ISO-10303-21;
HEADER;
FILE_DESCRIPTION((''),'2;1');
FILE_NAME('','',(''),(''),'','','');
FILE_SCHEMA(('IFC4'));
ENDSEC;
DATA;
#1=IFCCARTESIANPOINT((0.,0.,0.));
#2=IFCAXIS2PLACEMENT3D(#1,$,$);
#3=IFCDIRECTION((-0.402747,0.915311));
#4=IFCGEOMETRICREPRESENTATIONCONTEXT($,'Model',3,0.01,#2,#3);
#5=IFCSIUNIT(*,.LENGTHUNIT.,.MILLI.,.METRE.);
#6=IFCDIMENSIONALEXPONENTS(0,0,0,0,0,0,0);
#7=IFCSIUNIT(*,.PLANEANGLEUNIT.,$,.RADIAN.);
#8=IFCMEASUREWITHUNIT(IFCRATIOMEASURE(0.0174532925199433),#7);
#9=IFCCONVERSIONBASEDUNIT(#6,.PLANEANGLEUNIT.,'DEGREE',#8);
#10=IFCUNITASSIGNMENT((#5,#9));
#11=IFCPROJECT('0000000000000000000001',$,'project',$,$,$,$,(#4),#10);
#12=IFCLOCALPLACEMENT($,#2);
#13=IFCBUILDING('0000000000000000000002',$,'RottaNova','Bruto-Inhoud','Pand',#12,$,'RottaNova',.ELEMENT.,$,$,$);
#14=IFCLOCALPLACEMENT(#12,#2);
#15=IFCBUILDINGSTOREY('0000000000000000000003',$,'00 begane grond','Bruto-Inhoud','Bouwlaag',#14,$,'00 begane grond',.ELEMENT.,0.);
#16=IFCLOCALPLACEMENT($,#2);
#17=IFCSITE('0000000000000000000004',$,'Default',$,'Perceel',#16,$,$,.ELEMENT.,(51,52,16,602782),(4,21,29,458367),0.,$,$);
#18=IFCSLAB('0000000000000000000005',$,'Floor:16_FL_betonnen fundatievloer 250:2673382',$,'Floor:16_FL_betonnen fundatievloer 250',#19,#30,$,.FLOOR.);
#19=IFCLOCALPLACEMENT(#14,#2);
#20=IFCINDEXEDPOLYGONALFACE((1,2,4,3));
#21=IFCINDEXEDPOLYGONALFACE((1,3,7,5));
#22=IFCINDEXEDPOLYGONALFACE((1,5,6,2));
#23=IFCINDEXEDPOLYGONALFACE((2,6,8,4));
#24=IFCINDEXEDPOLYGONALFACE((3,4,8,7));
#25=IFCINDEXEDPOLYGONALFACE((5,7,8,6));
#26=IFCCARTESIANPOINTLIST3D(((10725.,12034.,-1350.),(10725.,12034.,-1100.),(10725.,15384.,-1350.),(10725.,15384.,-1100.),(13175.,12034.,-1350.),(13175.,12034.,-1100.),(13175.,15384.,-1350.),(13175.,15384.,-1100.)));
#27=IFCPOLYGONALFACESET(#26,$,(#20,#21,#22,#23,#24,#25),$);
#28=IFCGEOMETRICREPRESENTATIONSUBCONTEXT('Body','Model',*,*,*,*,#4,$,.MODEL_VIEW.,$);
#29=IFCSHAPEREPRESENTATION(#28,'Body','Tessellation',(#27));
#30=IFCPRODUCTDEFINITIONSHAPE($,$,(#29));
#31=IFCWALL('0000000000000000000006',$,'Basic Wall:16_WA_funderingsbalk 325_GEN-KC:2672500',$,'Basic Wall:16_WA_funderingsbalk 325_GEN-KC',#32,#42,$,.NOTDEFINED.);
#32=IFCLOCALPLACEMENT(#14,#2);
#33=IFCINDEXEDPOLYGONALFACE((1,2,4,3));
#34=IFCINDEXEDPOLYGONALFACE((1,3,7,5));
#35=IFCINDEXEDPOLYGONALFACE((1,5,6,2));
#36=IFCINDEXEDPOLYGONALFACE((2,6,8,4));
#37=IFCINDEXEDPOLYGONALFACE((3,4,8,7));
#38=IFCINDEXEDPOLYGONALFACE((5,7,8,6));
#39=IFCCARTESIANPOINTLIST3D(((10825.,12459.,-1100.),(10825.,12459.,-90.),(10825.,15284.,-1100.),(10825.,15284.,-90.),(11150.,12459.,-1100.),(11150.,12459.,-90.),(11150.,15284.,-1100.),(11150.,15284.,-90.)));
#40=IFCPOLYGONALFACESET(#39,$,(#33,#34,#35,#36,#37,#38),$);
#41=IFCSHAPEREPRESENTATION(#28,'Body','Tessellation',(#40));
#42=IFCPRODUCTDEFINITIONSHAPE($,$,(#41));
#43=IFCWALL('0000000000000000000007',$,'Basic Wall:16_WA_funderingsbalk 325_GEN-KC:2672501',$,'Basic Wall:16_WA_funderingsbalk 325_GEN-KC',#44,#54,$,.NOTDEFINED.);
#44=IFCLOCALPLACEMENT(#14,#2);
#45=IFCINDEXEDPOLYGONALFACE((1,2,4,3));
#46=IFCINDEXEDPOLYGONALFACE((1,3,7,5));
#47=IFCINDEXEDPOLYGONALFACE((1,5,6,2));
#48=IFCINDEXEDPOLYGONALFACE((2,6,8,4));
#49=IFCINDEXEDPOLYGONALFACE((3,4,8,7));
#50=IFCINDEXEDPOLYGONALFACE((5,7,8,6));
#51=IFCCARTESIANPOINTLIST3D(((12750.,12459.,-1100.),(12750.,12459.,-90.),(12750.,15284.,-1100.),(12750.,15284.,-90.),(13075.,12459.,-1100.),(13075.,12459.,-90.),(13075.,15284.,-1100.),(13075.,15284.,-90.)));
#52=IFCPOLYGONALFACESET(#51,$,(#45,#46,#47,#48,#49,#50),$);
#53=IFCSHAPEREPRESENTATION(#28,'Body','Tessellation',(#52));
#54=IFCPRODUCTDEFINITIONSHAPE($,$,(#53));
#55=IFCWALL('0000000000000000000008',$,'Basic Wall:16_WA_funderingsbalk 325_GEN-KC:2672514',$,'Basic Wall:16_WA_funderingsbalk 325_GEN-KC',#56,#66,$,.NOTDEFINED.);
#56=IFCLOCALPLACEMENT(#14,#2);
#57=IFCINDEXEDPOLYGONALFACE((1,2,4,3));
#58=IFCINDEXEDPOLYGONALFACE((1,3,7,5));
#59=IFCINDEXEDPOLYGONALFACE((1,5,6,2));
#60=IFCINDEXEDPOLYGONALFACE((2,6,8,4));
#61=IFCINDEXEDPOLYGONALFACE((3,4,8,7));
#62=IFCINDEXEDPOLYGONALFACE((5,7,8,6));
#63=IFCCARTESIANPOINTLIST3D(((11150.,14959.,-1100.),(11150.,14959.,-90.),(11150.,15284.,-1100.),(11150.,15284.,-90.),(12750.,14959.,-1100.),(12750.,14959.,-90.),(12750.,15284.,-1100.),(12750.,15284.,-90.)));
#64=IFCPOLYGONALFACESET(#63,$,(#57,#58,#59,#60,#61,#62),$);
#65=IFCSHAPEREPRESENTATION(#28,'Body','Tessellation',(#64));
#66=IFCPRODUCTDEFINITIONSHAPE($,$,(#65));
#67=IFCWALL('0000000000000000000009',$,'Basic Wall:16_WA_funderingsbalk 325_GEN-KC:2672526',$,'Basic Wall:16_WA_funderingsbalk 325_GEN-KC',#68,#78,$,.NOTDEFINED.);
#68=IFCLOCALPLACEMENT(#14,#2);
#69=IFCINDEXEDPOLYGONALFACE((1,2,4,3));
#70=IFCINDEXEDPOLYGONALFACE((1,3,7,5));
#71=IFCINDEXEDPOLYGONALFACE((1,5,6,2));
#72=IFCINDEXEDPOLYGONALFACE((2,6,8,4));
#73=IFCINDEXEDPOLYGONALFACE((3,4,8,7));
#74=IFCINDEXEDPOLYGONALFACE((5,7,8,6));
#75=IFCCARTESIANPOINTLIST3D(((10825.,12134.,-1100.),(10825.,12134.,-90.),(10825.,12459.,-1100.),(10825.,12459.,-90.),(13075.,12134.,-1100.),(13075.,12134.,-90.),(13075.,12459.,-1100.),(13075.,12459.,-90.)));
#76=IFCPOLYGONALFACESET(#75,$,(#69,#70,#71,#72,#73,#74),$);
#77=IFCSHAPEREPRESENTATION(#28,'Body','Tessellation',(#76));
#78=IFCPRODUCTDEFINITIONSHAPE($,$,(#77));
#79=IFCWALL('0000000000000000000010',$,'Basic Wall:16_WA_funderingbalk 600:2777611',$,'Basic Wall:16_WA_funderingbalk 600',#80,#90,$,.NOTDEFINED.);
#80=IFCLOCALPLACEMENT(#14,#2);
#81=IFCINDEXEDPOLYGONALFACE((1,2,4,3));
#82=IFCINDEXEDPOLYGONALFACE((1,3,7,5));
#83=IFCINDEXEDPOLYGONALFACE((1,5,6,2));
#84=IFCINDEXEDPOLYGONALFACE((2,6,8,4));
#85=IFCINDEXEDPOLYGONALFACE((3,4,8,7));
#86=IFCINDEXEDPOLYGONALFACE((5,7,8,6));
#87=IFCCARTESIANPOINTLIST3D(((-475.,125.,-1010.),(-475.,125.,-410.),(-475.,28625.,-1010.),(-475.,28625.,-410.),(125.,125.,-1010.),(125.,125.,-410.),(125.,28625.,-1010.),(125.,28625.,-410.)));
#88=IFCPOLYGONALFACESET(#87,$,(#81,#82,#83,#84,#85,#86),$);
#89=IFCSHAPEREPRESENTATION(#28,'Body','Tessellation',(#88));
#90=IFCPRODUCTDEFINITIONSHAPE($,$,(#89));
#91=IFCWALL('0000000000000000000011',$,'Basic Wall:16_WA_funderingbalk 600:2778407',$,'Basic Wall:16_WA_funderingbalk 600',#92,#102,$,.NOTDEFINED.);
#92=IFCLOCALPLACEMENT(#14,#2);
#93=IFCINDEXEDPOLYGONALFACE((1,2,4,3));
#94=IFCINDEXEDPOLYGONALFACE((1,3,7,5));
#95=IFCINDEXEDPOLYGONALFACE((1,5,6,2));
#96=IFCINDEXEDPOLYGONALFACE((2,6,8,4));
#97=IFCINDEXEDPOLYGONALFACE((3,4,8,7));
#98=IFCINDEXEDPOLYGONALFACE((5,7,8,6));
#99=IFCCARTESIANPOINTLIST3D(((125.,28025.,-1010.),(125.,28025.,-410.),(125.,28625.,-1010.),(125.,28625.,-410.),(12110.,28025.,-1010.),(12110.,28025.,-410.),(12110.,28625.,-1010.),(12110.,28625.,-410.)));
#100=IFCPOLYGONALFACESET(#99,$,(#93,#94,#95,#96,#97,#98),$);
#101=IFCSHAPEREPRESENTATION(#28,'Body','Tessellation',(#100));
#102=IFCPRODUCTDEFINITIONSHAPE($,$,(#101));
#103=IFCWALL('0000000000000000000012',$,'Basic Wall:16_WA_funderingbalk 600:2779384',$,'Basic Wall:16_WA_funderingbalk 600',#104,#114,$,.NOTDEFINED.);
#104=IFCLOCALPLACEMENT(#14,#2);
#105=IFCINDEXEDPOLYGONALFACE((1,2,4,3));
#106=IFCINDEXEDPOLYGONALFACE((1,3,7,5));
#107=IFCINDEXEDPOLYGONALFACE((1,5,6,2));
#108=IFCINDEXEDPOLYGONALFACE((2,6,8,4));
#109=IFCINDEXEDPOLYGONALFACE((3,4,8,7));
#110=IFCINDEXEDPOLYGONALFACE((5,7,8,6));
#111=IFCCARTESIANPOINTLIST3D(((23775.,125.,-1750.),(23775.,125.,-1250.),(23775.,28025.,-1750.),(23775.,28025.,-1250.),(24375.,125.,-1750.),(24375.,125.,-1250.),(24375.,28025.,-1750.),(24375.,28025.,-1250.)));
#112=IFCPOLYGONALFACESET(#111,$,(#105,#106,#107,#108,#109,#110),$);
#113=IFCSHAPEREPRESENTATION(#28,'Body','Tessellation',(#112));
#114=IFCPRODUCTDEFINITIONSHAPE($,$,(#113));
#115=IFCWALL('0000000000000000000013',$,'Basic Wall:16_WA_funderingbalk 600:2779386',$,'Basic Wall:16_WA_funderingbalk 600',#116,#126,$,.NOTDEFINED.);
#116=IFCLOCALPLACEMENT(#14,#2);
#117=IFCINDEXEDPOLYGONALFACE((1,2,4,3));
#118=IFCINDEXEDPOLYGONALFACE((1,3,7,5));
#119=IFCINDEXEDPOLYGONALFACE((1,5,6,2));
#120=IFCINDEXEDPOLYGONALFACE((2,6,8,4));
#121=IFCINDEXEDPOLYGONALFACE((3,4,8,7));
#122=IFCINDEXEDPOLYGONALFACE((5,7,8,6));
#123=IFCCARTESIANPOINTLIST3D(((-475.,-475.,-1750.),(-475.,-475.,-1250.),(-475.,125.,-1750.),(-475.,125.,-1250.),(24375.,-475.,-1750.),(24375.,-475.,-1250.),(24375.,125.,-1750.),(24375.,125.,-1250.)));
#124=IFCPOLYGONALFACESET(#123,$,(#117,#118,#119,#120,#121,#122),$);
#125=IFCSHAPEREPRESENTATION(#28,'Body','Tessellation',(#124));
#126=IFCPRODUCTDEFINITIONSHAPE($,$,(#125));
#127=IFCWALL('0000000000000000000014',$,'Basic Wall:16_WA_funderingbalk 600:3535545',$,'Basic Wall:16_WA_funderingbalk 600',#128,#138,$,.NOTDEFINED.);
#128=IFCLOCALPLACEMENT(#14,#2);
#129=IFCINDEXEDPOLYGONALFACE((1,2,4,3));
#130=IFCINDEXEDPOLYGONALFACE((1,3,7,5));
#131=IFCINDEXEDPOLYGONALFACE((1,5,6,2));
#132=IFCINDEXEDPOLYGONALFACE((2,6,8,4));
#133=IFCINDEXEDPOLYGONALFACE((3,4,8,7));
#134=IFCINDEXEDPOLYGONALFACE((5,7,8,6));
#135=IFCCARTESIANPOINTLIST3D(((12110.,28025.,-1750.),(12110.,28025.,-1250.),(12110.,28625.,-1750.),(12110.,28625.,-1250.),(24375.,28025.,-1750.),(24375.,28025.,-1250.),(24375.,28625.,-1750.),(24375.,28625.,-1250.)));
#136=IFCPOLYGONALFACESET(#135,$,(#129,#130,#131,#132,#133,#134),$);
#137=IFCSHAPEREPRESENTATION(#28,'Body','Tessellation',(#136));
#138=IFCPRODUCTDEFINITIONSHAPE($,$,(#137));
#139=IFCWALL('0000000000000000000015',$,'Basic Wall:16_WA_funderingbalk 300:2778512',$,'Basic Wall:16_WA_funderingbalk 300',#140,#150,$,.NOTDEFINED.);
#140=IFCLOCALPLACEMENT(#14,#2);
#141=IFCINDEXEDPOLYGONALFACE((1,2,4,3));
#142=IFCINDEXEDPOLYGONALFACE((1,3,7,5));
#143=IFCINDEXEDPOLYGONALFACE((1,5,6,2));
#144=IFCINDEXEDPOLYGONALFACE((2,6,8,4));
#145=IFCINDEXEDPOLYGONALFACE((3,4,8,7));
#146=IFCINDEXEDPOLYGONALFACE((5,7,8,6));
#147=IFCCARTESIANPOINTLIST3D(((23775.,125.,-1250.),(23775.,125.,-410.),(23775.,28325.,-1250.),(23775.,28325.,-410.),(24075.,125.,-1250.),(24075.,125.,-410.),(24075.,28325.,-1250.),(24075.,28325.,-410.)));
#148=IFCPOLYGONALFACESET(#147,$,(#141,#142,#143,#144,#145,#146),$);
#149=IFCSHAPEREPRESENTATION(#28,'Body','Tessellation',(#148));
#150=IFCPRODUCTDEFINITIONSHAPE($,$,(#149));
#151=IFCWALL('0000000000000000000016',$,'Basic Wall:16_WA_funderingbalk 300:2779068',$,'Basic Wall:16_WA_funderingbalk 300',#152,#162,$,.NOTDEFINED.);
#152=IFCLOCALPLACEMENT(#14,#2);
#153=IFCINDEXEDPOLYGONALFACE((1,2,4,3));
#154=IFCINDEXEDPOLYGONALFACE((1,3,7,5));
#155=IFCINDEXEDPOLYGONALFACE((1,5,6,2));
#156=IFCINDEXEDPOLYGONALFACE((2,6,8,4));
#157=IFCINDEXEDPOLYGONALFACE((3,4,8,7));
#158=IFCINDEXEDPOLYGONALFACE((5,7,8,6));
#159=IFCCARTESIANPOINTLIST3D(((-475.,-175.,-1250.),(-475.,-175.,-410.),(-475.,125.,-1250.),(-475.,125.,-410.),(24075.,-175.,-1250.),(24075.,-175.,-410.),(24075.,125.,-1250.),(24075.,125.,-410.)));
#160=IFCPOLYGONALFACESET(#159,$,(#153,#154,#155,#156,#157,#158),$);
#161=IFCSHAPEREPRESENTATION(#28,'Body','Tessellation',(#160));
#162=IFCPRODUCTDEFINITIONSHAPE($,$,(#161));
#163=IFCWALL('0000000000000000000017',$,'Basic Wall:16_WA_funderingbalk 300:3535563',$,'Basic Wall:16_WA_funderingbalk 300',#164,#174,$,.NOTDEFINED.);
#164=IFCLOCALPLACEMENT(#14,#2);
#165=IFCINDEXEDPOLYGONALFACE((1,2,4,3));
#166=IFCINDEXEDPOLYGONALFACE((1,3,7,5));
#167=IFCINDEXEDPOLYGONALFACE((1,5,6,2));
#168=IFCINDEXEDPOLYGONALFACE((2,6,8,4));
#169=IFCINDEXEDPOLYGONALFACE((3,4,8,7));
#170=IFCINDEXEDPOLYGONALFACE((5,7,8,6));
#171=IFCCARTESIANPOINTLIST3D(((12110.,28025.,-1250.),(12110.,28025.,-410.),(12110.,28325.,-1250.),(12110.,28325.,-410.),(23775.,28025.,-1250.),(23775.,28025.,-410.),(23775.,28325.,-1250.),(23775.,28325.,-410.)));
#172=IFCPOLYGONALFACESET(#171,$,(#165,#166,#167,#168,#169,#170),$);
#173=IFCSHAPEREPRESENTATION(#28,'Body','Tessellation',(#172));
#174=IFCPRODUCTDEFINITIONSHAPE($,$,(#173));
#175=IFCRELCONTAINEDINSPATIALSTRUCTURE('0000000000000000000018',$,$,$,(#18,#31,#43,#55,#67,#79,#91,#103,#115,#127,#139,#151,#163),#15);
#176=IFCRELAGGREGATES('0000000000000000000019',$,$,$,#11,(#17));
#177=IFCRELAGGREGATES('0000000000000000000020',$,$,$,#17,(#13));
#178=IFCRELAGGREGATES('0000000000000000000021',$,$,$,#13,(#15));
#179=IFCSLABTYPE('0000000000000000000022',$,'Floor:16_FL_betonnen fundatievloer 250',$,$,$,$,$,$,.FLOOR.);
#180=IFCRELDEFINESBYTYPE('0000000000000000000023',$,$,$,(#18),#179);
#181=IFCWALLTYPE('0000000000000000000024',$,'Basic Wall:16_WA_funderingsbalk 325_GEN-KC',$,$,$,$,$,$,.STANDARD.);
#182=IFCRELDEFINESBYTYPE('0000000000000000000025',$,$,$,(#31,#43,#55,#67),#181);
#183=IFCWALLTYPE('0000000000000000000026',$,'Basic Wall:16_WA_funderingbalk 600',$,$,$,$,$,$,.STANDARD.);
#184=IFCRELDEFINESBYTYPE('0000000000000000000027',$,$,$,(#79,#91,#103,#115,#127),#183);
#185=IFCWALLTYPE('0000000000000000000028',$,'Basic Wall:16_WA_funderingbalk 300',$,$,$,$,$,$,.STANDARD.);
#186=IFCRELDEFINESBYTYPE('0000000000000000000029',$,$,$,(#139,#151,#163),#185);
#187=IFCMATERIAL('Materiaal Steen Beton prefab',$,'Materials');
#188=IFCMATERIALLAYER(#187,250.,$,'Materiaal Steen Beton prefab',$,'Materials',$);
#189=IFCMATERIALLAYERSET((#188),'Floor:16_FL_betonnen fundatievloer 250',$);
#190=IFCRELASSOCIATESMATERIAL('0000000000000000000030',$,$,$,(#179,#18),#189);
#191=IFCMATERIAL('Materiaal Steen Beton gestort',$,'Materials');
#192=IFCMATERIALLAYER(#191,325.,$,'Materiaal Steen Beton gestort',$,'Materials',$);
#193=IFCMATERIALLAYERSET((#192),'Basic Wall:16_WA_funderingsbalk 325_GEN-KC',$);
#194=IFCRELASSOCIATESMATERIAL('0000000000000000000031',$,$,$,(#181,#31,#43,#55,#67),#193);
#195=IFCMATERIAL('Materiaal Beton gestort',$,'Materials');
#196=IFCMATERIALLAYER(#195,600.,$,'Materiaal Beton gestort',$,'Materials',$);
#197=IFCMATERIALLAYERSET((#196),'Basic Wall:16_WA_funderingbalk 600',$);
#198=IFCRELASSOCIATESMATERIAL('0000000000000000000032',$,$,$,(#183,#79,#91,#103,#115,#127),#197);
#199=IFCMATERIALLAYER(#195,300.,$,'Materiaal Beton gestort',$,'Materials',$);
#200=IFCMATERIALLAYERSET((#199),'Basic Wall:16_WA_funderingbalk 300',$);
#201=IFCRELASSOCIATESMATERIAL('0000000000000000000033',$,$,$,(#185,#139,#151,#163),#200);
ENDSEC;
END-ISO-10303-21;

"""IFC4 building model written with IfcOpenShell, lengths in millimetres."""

from ifc_helpers import new_model, entity, si_unit, converted_unit, direction, frame, frame_2d, origin, origin_2d_with_axis, place, context, subcontext, project, spatial, rectangle, extrude, material, layer, layer_set, layer_usage, type_object, element, save


model = new_model("IFC4")

# Units and contexts
model_context = context("Model", 3, precision=0.01, world=origin(), true_north=direction((-0.402747, 0.915311)))
body_context = subcontext(model_context, "Body", "Model", "MODEL_VIEW")
ifc_project = project(units=[si_unit("LENGTHUNIT", "METRE", prefix="MILLI"), converted_unit("PLANEANGLEUNIT", "DEGREE", entity("IfcRatioMeasure", 0.0174532925199433), si_unit("PLANEANGLEUNIT", "RADIAN"), dimensions=[0, 0, 0, 0, 0, 0, 0])], contexts=[model_context])

# Site, building, storey
site_placement = place(None, origin())
site = spatial("IfcSite", under=ifc_project, at=site_placement, Name="Default", ObjectType="Perceel", CompositionType="ELEMENT", RefLatitude=(51, 52, 16, 602782), RefLongitude=(4, 21, 29, 458367), RefElevation=0.0)
building_placement = place(None, origin())
building = spatial("IfcBuilding", under=site, at=building_placement, Name="RottaNova", Description="Bruto-Inhoud", ObjectType="Pand", LongName="RottaNova", CompositionType="ELEMENT")
storey_placement = place(building_placement, origin())
storey = spatial("IfcBuildingStorey", under=building, at=storey_placement, Name="00 begane grond", Description="Bruto-Inhoud", ObjectType="Bouwlaag", LongName="00 begane grond", CompositionType="ELEMENT", Elevation=0.0)

# Slab
ifc_material_1 = material(Name="Materiaal Steen Beton prefab", Category="Materials")
ifc_layer_1 = layer(ifc_material_1, 250.0, Name="Materiaal Steen Beton prefab", Category="Materials")
ifc_layer_set_1 = layer_set([ifc_layer_1], Name="Floor:16_FL_betonnen fundatievloer 250")
ifc_layer_usage = layer_usage(ifc_layer_set_1, "AXIS3", "POSITIVE", 0.0)
slab_type = type_object("IfcSlabType", Name="Floor:16_FL_betonnen fundatievloer 250", PredefinedType="FLOOR", material=ifc_layer_set_1)
slab_placement = place(storey_placement, origin())
element("IfcSlab", 1, at=slab_placement, inside=storey, type_object=slab_type, material=ifc_layer_usage, Name="Floor:16_FL_betonnen fundatievloer 250:2673382", ObjectType="Floor:16_FL_betonnen fundatievloer 250", PredefinedType="FLOOR", context=body_context, shape_type="SweptSolid", body=[
    extrude(rectangle(XDim=3350.0, YDim=2450.0, at=origin_2d_with_axis()), frame((11950.0, 13709.0, -1100.0), z_axis=(0.0, 0.0, -1.0), x_axis=(0.0, 1.0, 0.0)), (0.0, 0.0, 1.0), 250.0),
])

# Walls
ifc_material_2 = material(Name="Materiaal Steen Beton gestort", Category="Materials")
ifc_layer_2 = layer(ifc_material_2, 325.0, Name="Materiaal Steen Beton gestort", Category="Materials")
ifc_layer_set_2 = layer_set([ifc_layer_2], Name="Basic Wall:16_WA_funderingsbalk 325_GEN-KC")
wall_type_1 = type_object("IfcWallType", Name="Basic Wall:16_WA_funderingsbalk 325_GEN-KC", PredefinedType="STANDARD", material=ifc_layer_set_2)
for number, where, z_axis, x_axis, name in (
    (2, (10987.5, 12459.0, -1100.0), (0.0, 0.0, 1.0), (0.0, 1.0, 0.0), "Basic Wall:16_WA_funderingsbalk 325_GEN-KC:2672500"),
    (3, (12912.5, 12459.0, -1100.0), (0.0, 0.0, 1.0), (0.0, 1.0, 0.0), "Basic Wall:16_WA_funderingsbalk 325_GEN-KC:2672501"),
):
    element("IfcWall", number, at=place(storey_placement, frame(where, z_axis=z_axis, x_axis=x_axis)), inside=storey, type_object=wall_type_1, material=ifc_layer_set_2, Name=name, ObjectType="Basic Wall:16_WA_funderingsbalk 325_GEN-KC", PredefinedType="NOTDEFINED", context=body_context, shape_type="SweptSolid", body=[
        extrude(rectangle(XDim=2825.0, YDim=325.0, at=frame_2d((1412.5, 0.0), x_axis=(-1.0, 0.0))), origin(), (0.0, 0.0, 1.0), 1010.0),
    ])
wall_1_placement = place(storey_placement, frame((11150.0, 15121.5, -1100.0)))
element("IfcWall", 4, at=wall_1_placement, inside=storey, type_object=wall_type_1, material=ifc_layer_set_2, Name="Basic Wall:16_WA_funderingsbalk 325_GEN-KC:2672514", ObjectType="Basic Wall:16_WA_funderingsbalk 325_GEN-KC", PredefinedType="NOTDEFINED", context=body_context, shape_type="SweptSolid", body=[
    extrude(rectangle(XDim=1600.0, YDim=325.0, at=frame_2d((800.0, 0.0), x_axis=(-1.0, 0.0))), origin(), (0.0, 0.0, 1.0), 1010.0),
])
wall_2_placement = place(storey_placement, frame((10825.0, 12296.5, -1100.0)))
element("IfcWall", 5, at=wall_2_placement, inside=storey, type_object=wall_type_1, material=ifc_layer_set_2, Name="Basic Wall:16_WA_funderingsbalk 325_GEN-KC:2672526", ObjectType="Basic Wall:16_WA_funderingsbalk 325_GEN-KC", PredefinedType="NOTDEFINED", context=body_context, shape_type="SweptSolid", body=[
    extrude(rectangle(XDim=2250.0, YDim=325.0, at=frame_2d((1125.0, 0.0), x_axis=(-1.0, 0.0))), origin(), (0.0, 0.0, 1.0), 1010.0),
])
ifc_material_3 = material(Name="Materiaal Beton gestort", Category="Materials")
ifc_layer_3 = layer(ifc_material_3, 600.0, Name="Materiaal Beton gestort", Category="Materials")
ifc_layer_set_3 = layer_set([ifc_layer_3], Name="Basic Wall:16_WA_funderingbalk 600")
wall_type_2 = type_object("IfcWallType", Name="Basic Wall:16_WA_funderingbalk 600", PredefinedType="STANDARD", material=ifc_layer_set_3)
wall_3_placement = place(storey_placement, frame((-175.0, 125.0, -1010.0), z_axis=(0.0, 0.0, 1.0), x_axis=(0.0, 1.0, 0.0)))
element("IfcWall", 6, at=wall_3_placement, inside=storey, type_object=wall_type_2, material=ifc_layer_set_3, Name="Basic Wall:16_WA_funderingbalk 600:2777611", ObjectType="Basic Wall:16_WA_funderingbalk 600", PredefinedType="NOTDEFINED", context=body_context, shape_type="SweptSolid", body=[
    extrude(rectangle(XDim=28500.0, YDim=600.0, at=frame_2d((14250.0, 0.0), x_axis=(-1.0, 0.0))), origin(), (0.0, 0.0, 1.0), 600.0),
])
wall_4_placement = place(storey_placement, frame((125.0, 28325.0, -1010.0)))
element("IfcWall", 7, at=wall_4_placement, inside=storey, type_object=wall_type_2, material=ifc_layer_set_3, Name="Basic Wall:16_WA_funderingbalk 600:2778407", ObjectType="Basic Wall:16_WA_funderingbalk 600", PredefinedType="NOTDEFINED", context=body_context, shape_type="SweptSolid", body=[
    extrude(rectangle(XDim=11985.0, YDim=600.0, at=frame_2d((5992.5, 0.0), x_axis=(-1.0, 0.0))), origin(), (0.0, 0.0, 1.0), 600.0),
])
wall_5_placement = place(storey_placement, frame((24075.0, 125.0, -1750.0), z_axis=(0.0, 0.0, 1.0), x_axis=(0.0, 1.0, 0.0)))
element("IfcWall", 8, at=wall_5_placement, inside=storey, type_object=wall_type_2, material=ifc_layer_set_3, Name="Basic Wall:16_WA_funderingbalk 600:2779384", ObjectType="Basic Wall:16_WA_funderingbalk 600", PredefinedType="NOTDEFINED", context=body_context, shape_type="SweptSolid", body=[
    extrude(rectangle(XDim=27900.0, YDim=600.0, at=frame_2d((13950.0, 0.0), x_axis=(-1.0, 0.0))), origin(), (0.0, 0.0, 1.0), 500.0),
])
wall_6_placement = place(storey_placement, frame((-475.0, -175.0, -1750.0)))
element("IfcWall", 9, at=wall_6_placement, inside=storey, type_object=wall_type_2, material=ifc_layer_set_3, Name="Basic Wall:16_WA_funderingbalk 600:2779386", ObjectType="Basic Wall:16_WA_funderingbalk 600", PredefinedType="NOTDEFINED", context=body_context, shape_type="SweptSolid", body=[
    extrude(rectangle(XDim=24850.0, YDim=600.0, at=frame_2d((12425.0, 0.0), x_axis=(-1.0, 0.0))), origin(), (0.0, 0.0, 1.0), 500.0),
])
wall_7_placement = place(storey_placement, frame((12110.0, 28325.0, -1750.0)))
element("IfcWall", 10, at=wall_7_placement, inside=storey, type_object=wall_type_2, material=ifc_layer_set_3, Name="Basic Wall:16_WA_funderingbalk 600:3535545", ObjectType="Basic Wall:16_WA_funderingbalk 600", PredefinedType="NOTDEFINED", context=body_context, shape_type="SweptSolid", body=[
    extrude(rectangle(XDim=12265.0, YDim=600.0, at=frame_2d((6132.5, 0.0), x_axis=(-1.0, 0.0))), origin(), (0.0, 0.0, 1.0), 500.0),
])
ifc_layer_4 = layer(ifc_material_3, 300.0, Name="Materiaal Beton gestort", Category="Materials")
ifc_layer_set_4 = layer_set([ifc_layer_4], Name="Basic Wall:16_WA_funderingbalk 300")
wall_type_3 = type_object("IfcWallType", Name="Basic Wall:16_WA_funderingbalk 300", PredefinedType="STANDARD", material=ifc_layer_set_4)
wall_8_placement = place(storey_placement, frame((23925.0, 125.0, -1250.0), z_axis=(0.0, 0.0, 1.0), x_axis=(0.0, 1.0, 0.0)))
element("IfcWall", 11, at=wall_8_placement, inside=storey, type_object=wall_type_3, material=ifc_layer_set_4, Name="Basic Wall:16_WA_funderingbalk 300:2778512", ObjectType="Basic Wall:16_WA_funderingbalk 300", PredefinedType="NOTDEFINED", context=body_context, shape_type="SweptSolid", body=[
    extrude(rectangle(XDim=28200.0, YDim=300.0, at=frame_2d((14100.0, 0.0), x_axis=(-1.0, 0.0))), origin(), (0.0, 0.0, 1.0), 840.0),
])
wall_9_placement = place(storey_placement, frame((-475.0, -25.0, -1250.0)))
element("IfcWall", 12, at=wall_9_placement, inside=storey, type_object=wall_type_3, material=ifc_layer_set_4, Name="Basic Wall:16_WA_funderingbalk 300:2779068", ObjectType="Basic Wall:16_WA_funderingbalk 300", PredefinedType="NOTDEFINED", context=body_context, shape_type="SweptSolid", body=[
    extrude(rectangle(XDim=24550.0, YDim=300.0, at=frame_2d((12275.0, 0.0), x_axis=(-1.0, 0.0))), origin(), (0.0, 0.0, 1.0), 840.0),
])
wall_10_placement = place(storey_placement, frame((12110.0, 28175.0, -1250.0)))
element("IfcWall", 13, at=wall_10_placement, inside=storey, type_object=wall_type_3, material=ifc_layer_set_4, Name="Basic Wall:16_WA_funderingbalk 300:3535563", ObjectType="Basic Wall:16_WA_funderingbalk 300", PredefinedType="NOTDEFINED", context=body_context, shape_type="SweptSolid", body=[
    extrude(rectangle(XDim=11665.0, YDim=300.0, at=frame_2d((5832.5, 0.0), x_axis=(-1.0, 0.0))), origin(), (0.0, 0.0, 1.0), 840.0),
])

save(model, "model.ifc")
